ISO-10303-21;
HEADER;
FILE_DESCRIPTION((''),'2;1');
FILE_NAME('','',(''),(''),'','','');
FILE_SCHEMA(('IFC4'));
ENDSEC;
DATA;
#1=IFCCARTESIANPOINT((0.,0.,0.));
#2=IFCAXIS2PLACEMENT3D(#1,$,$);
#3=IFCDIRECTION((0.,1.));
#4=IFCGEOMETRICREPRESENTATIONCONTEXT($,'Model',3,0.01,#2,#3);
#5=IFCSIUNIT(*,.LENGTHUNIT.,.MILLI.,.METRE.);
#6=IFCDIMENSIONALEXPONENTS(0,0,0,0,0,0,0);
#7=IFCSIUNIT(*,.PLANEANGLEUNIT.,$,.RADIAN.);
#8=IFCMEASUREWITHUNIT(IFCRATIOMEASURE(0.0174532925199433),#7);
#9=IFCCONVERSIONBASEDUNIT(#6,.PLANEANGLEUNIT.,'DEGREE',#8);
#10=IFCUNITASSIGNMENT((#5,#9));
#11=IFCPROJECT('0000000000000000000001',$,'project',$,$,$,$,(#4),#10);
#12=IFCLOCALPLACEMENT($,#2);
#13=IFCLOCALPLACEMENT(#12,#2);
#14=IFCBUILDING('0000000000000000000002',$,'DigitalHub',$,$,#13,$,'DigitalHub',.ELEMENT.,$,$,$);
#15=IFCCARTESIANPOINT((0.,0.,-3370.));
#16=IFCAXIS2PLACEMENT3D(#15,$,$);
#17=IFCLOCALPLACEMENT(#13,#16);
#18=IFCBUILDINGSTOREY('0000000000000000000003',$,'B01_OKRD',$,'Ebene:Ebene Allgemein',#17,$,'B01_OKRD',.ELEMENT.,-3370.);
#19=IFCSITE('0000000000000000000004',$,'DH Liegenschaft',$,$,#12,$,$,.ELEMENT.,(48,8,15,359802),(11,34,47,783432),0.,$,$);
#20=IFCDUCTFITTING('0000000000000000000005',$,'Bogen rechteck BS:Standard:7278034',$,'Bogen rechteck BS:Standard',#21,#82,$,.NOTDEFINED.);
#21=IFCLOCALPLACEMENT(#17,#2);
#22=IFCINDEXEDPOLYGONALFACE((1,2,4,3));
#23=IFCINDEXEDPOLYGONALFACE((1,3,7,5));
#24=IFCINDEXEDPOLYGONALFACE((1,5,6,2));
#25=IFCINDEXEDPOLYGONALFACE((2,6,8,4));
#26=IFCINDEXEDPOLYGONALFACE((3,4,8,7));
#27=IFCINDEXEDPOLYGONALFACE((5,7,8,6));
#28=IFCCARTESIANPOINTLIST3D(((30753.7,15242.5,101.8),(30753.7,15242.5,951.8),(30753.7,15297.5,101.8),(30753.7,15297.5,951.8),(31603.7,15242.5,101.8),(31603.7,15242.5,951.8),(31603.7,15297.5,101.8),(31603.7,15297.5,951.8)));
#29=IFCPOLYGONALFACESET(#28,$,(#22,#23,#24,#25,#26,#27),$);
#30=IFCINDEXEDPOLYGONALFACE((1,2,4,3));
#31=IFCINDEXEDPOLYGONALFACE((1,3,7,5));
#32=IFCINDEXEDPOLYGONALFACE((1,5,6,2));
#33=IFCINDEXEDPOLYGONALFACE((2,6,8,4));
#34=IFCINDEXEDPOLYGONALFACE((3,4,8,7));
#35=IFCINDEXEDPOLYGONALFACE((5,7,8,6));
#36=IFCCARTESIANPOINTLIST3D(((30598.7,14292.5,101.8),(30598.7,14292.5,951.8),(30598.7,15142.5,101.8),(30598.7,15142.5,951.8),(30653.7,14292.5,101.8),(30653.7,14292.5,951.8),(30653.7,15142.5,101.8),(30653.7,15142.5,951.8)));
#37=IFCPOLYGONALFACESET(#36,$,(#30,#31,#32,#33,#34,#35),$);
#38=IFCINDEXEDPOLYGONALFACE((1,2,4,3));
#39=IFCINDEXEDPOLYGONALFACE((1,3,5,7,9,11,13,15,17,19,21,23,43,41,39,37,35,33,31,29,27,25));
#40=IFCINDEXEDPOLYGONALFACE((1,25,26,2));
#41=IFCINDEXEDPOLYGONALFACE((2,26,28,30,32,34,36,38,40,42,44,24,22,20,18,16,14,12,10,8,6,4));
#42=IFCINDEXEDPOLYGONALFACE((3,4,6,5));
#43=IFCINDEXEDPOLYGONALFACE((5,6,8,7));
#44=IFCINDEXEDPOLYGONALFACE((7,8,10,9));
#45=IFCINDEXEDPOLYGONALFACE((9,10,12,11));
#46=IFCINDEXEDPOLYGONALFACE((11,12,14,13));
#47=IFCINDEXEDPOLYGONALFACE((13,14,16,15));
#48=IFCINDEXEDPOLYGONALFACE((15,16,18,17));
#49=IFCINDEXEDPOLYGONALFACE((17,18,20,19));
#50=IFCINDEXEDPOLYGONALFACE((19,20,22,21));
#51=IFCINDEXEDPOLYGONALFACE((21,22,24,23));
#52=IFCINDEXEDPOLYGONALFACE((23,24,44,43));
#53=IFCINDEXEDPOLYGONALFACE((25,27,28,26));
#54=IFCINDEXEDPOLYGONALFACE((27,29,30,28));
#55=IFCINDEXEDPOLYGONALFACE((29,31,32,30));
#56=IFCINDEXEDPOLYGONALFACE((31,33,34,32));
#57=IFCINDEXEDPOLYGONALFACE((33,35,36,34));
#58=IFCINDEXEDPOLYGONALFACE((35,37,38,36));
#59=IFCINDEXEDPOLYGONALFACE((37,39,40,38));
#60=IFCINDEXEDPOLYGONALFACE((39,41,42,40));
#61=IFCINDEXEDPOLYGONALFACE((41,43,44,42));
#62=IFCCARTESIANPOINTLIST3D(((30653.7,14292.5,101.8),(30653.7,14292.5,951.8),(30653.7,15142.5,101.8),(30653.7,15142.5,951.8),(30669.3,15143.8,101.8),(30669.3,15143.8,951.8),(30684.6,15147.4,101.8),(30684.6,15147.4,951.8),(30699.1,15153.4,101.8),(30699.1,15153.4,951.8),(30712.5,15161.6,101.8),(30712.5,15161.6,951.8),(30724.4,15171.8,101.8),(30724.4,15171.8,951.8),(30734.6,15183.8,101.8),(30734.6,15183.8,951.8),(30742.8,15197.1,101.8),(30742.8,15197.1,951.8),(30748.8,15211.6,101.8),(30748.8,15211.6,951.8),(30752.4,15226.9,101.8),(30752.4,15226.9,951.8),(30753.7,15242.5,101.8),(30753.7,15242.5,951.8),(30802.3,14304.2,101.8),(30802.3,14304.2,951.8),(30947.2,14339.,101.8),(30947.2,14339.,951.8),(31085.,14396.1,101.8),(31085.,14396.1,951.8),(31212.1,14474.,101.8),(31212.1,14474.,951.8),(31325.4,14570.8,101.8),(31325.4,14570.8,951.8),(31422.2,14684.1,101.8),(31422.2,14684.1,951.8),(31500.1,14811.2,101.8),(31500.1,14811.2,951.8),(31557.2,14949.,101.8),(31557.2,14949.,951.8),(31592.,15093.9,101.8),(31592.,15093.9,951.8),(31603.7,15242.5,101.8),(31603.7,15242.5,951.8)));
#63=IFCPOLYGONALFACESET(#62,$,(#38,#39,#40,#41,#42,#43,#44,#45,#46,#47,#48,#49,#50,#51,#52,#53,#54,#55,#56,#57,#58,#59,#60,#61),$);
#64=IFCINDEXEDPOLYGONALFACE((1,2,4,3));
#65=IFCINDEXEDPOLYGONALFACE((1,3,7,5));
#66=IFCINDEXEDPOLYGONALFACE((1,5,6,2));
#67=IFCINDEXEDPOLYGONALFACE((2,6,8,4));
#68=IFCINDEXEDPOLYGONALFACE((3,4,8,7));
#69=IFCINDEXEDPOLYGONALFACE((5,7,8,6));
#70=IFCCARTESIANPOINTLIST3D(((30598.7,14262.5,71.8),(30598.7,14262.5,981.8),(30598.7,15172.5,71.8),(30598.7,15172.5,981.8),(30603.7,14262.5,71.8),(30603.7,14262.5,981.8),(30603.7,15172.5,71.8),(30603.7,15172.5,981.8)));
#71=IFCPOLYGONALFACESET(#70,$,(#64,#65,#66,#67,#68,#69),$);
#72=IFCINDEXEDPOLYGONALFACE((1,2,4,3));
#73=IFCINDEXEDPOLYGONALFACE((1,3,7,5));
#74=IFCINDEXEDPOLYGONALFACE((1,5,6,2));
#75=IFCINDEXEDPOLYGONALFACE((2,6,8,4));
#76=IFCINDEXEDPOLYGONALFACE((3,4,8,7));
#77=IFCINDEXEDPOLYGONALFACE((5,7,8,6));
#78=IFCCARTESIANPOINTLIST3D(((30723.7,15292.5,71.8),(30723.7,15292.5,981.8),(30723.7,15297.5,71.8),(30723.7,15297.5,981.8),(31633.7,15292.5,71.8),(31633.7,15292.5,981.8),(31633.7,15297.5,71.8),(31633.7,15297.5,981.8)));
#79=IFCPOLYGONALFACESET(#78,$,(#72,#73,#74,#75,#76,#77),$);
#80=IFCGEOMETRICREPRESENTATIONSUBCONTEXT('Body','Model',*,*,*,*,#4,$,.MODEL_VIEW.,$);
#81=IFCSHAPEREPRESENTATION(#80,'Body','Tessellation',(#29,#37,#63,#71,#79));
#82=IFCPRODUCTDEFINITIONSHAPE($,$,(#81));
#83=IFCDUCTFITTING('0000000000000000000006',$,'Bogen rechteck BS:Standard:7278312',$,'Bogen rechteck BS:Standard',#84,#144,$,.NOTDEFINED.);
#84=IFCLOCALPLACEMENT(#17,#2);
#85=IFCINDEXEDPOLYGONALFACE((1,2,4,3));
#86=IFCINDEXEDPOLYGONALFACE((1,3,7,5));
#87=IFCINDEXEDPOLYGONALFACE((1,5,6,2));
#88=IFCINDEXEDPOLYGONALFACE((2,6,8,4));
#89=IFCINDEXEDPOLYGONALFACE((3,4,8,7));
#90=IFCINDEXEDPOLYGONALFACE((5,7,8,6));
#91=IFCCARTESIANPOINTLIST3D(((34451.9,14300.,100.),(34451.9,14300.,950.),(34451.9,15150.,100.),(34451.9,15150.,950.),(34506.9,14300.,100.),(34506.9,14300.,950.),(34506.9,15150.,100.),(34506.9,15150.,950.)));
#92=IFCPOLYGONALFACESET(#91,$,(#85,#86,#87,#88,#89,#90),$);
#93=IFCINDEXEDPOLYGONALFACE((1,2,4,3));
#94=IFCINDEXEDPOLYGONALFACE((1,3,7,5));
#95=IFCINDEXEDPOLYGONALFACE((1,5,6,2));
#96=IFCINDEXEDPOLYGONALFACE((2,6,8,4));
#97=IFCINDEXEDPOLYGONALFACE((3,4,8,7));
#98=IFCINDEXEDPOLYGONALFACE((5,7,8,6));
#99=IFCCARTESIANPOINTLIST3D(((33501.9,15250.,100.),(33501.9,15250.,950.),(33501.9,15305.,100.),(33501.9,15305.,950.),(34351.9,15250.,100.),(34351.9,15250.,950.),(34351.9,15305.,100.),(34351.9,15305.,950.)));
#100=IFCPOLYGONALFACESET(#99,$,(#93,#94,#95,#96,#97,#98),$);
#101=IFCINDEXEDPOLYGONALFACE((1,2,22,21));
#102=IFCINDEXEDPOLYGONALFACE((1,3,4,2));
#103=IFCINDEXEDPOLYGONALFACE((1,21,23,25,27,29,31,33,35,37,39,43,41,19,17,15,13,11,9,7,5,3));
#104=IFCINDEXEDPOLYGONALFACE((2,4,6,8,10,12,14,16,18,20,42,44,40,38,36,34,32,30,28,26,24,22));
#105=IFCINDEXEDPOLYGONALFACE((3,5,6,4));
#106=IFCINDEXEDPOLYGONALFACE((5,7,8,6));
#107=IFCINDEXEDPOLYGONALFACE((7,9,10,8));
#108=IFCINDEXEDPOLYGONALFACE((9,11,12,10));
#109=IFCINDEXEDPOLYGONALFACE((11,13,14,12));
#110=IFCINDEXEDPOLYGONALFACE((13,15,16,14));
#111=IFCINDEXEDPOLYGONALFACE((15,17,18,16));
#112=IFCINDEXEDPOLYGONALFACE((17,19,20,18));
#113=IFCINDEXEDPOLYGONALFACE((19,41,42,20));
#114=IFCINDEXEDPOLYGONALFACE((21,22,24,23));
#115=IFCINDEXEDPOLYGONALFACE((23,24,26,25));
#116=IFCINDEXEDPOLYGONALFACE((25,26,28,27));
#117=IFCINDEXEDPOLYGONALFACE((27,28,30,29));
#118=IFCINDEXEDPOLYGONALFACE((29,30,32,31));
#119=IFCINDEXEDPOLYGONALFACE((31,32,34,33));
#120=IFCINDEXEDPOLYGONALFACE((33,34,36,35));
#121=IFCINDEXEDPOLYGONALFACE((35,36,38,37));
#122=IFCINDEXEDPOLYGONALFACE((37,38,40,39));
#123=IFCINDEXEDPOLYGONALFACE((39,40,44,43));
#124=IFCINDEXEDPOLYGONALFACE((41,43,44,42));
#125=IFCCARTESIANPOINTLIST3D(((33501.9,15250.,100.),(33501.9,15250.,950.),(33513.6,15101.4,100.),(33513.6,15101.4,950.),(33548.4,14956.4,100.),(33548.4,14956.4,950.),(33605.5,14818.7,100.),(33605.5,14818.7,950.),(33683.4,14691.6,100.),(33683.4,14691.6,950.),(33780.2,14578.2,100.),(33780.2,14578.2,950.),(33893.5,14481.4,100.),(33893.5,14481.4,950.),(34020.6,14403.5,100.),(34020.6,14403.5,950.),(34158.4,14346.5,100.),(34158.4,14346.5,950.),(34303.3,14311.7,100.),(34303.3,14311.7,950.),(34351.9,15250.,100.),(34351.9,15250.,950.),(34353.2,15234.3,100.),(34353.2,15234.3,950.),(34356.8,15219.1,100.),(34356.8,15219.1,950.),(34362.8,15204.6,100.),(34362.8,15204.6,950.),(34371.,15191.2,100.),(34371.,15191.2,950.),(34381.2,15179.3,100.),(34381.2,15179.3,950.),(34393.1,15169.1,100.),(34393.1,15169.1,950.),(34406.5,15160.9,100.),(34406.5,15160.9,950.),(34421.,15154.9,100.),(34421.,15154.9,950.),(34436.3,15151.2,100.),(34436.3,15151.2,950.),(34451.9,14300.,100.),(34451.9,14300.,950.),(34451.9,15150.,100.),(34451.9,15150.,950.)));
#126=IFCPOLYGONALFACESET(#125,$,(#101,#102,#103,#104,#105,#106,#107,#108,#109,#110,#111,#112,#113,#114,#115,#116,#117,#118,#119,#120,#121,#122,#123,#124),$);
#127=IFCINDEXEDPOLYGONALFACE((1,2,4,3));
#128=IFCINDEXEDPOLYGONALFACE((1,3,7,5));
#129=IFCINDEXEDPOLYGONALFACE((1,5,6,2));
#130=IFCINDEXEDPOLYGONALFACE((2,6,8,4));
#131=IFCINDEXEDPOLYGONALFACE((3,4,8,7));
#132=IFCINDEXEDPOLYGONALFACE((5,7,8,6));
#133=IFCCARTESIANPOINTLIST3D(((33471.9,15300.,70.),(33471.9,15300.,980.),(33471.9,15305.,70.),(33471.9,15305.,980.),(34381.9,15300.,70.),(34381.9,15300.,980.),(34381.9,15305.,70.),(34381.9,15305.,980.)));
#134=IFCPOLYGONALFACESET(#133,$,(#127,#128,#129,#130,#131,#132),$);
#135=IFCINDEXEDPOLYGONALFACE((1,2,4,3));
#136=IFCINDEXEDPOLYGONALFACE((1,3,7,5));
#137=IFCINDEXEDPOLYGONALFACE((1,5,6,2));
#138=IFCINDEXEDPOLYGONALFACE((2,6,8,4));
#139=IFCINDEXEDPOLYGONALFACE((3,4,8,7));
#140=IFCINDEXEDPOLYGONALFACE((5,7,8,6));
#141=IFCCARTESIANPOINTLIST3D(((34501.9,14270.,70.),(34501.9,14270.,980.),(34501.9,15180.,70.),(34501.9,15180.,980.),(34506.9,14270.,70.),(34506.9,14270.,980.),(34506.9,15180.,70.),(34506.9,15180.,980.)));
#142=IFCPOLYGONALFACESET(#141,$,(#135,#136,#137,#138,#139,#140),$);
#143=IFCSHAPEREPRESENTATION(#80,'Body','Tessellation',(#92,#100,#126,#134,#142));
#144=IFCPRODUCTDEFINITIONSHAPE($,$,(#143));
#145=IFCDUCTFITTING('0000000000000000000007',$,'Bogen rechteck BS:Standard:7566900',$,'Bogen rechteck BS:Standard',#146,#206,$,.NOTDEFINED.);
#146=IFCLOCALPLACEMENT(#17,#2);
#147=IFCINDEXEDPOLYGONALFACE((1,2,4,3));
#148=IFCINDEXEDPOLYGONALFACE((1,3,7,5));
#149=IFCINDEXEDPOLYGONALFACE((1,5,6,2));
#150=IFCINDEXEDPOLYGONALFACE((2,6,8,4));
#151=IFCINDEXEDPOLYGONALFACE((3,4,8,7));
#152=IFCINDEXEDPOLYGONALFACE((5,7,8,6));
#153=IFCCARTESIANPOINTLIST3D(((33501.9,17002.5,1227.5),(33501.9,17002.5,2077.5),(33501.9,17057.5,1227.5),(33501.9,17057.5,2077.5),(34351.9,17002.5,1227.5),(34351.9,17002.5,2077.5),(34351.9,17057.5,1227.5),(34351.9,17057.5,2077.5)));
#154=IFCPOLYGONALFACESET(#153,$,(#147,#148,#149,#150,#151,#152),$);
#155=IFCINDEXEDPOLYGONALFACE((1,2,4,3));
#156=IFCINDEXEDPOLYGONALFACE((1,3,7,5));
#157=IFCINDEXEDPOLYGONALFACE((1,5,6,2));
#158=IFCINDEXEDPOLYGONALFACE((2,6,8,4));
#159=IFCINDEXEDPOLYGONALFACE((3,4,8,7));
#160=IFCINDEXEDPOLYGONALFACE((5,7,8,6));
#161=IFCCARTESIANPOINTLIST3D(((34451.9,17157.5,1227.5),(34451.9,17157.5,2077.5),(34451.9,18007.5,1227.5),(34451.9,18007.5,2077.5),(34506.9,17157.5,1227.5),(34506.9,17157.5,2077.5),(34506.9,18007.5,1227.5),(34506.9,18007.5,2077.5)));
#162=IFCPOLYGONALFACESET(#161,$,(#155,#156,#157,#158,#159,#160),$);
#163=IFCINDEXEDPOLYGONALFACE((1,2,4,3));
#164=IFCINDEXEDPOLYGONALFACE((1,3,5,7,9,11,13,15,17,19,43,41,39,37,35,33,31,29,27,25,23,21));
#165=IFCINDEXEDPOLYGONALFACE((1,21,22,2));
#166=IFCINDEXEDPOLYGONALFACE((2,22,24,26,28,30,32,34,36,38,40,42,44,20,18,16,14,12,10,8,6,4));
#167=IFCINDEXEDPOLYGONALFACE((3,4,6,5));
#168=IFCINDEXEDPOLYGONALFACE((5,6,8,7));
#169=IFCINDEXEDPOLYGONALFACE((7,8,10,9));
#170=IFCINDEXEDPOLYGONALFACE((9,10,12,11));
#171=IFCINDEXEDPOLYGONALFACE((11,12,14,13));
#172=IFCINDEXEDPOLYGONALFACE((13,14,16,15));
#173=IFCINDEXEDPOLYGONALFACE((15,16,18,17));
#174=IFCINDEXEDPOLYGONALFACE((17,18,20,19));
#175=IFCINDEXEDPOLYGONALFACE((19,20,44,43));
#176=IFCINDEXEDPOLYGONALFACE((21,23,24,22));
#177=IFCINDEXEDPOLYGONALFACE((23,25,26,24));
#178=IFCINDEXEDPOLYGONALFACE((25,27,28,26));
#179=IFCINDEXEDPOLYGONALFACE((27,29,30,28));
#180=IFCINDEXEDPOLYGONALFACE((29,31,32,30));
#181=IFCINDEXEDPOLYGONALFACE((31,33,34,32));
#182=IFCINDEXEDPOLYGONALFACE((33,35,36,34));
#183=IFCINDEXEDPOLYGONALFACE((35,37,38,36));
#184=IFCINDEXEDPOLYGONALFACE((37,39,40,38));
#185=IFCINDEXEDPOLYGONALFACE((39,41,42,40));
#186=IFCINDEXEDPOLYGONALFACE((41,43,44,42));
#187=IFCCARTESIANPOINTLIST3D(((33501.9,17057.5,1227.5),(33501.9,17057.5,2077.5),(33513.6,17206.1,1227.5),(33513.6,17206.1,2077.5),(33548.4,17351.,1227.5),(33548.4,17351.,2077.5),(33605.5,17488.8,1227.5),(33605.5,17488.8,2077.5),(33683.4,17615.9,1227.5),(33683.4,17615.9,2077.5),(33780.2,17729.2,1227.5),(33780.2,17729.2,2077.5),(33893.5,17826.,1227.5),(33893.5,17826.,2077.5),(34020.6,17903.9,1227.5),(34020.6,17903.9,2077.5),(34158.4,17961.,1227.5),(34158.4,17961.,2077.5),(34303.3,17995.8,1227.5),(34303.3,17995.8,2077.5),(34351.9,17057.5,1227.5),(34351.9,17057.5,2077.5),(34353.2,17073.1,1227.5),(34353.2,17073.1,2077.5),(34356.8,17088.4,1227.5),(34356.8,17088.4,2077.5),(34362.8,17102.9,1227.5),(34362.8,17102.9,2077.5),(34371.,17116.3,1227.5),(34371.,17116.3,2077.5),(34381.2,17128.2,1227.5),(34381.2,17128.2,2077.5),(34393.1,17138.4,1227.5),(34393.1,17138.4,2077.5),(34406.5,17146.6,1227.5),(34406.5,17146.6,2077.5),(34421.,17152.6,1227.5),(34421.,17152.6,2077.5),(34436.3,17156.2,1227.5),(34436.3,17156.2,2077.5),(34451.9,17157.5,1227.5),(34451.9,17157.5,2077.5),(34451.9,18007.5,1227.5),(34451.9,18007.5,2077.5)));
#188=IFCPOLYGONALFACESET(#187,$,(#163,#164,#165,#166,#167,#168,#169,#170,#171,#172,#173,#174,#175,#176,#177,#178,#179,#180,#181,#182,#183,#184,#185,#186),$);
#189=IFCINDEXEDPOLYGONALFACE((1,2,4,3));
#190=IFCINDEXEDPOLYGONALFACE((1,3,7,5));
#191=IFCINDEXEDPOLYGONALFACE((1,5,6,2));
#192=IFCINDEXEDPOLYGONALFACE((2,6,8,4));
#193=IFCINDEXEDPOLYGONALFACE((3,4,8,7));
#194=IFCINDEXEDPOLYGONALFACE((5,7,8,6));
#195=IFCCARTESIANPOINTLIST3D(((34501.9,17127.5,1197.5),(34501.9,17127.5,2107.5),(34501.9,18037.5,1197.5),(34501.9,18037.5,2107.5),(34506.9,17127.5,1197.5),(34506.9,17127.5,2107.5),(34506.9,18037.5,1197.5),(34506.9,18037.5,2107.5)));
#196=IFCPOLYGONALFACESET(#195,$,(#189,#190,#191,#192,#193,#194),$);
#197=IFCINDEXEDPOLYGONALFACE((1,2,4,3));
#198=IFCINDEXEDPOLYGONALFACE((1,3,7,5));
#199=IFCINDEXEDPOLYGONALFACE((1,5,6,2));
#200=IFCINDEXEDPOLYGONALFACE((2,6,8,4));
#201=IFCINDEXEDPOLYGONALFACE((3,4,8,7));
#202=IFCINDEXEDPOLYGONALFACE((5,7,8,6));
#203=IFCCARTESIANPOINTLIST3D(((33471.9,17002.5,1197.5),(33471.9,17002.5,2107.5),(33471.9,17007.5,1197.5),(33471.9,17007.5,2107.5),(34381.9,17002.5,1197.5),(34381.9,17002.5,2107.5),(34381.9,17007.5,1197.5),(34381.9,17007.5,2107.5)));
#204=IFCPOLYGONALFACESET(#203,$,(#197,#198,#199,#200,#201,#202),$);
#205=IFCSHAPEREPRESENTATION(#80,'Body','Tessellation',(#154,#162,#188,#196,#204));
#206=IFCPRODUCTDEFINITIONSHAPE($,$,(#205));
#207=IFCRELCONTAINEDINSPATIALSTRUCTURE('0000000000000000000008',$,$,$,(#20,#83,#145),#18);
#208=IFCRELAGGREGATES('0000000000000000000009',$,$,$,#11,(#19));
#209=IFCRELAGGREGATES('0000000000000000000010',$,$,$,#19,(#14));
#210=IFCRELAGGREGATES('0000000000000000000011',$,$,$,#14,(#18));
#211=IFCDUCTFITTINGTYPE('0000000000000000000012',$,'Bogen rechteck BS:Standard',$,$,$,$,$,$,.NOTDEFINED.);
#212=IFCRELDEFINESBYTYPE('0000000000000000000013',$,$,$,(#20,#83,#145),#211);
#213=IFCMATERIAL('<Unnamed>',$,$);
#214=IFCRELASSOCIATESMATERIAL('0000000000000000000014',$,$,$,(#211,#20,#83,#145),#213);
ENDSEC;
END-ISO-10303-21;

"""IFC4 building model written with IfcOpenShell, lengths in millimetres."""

from ifc_helpers import new_model, entity, si_unit, converted_unit, direction, frame, origin, place, context, subcontext, project, spatial, indexed_curve, outline, extrude, source, transform, mapped, material, type_object, type_shapes, element, save


model = new_model("IFC4")

# Units and contexts
model_context = context("Model", 3, precision=0.01, world=origin(), true_north=direction((0.0, 1.0)))
body_context = subcontext(model_context, "Body", "Model", "MODEL_VIEW")
ifc_project = project(units=[si_unit("LENGTHUNIT", "METRE", prefix="MILLI"), converted_unit("PLANEANGLEUNIT", "DEGREE", entity("IfcRatioMeasure", 0.0174532925199433), si_unit("PLANEANGLEUNIT", "RADIAN"), dimensions=[0, 0, 0, 0, 0, 0, 0])], contexts=[model_context])

# Site, building, storey
site_placement = place(None, origin())
site = spatial("IfcSite", under=ifc_project, at=site_placement, Name="DH Liegenschaft", CompositionType="ELEMENT", RefLatitude=(48, 8, 15, 359802), RefLongitude=(11, 34, 47, 783432), RefElevation=0.0)
building_placement = place(site_placement, origin())
building = spatial("IfcBuilding", under=site, at=building_placement, Name="DigitalHub", LongName="DigitalHub", CompositionType="ELEMENT")
storey_placement = place(building_placement, frame((0.0, 0.0, -3370.0)))
storey = spatial("IfcBuildingStorey", under=building, at=storey_placement, Name="B01_OKRD", ObjectType="Ebene:Ebene Allgemein", LongName="B01_OKRD", CompositionType="ELEMENT", Elevation=-3370.0)

# Duct fittings
ifc_material_1 = material(Name="<Unnamed>")
duct_fitting_type_1 = type_object("IfcDuctFittingType", Name="Bogen rechteck BS:Standard", PredefinedType="NOTDEFINED", material=ifc_material_1)
shared_shape_1 = source(origin(), body_context, "Body", "SweptSolid", [
    extrude(outline(indexed_curve([(-27.5, -425.0), (27.5, -425.0), (27.5, 425.0), (-27.5, 425.0), (-27.5, -425.0)], self_intersect=False)), frame((0.0, 552.5, -425.0), z_axis=(0.0, 0.0, 1.0), x_axis=(0.0, 1.0, 0.0)), (0.0, 0.0, 1.0), 850.0),
    extrude(outline(indexed_curve([(-425.0, -27.5), (425.0, -27.5), (425.0, 27.5), (-425.0, 27.5), (-425.0, -27.5)], self_intersect=False)), frame((-552.5, 0.0, -425.0), z_axis=(0.0, 0.0, 1.0), x_axis=(0.0, -1.0, 0.0)), (0.0, 0.0, 1.0), 850.0),
    extrude(outline(indexed_curve([(-687.5, -262.5), (162.5, -262.5), (163.7, -246.9), (167.4, -231.6), (173.4, -217.1), (181.6, -203.7), (191.8, -191.8), (203.7, -181.6), (217.1, -173.4), (231.6, -167.4), (246.9, -163.7), (262.5, -162.5), (262.5, 687.5), (113.9, 675.8), (-31.1, 641.0), (-168.8, 584.0), (-295.9, 506.1), (-409.3, 409.3), (-506.1, 295.9), (-584.0, 168.8), (-641.0, 31.1), (-675.8, -113.9), (-687.5, -262.5)], self_intersect=False)), frame((-262.5, 262.5, -425.0), z_axis=(0.0, 0.0, 1.0), x_axis=(-1.0, 0.0, 0.0)), (0.0, 0.0, 1.0), 850.0),
    extrude(outline(indexed_curve([(-2.5, -455.0), (2.5, -455.0), (2.5, 455.0), (-2.5, 455.0), (-2.5, -455.0)], self_intersect=False)), frame((-577.5, 0.0, -455.0)), (0.0, 0.0, 1.0), 910.0),
    extrude(outline(indexed_curve([(-2.5, -455.0), (2.5, -455.0), (2.5, 455.0), (-2.5, 455.0), (-2.5, -455.0)], self_intersect=False)), frame((0.0, 577.5, -455.0), z_axis=(0.0, 0.0, 1.0), x_axis=(0.0, 1.0, 0.0)), (0.0, 0.0, 1.0), 910.0),
])
type_shapes(duct_fitting_type_1, [shared_shape_1])
duct_fitting_1_placement = place(storey_placement, frame((31178.7, 14717.5, 526.8)))
element("IfcDuctFitting", 1, at=duct_fitting_1_placement, inside=storey, type_object=duct_fitting_type_1, material=ifc_material_1, Name="Bogen rechteck BS:Standard:7278034", ObjectType="Bogen rechteck BS:Standard", PredefinedType="NOTDEFINED", context=body_context, shape_type="MappedRepresentation", body=[
    mapped(shared_shape_1, transform((0.0, 0.0, 0.0), scale=1.0)),
])
for number, where, z_axis, x_axis, name in (
    (2, (33926.9, 14725.0, 525.0), (0.0, 0.0, 1.0), (0.0, -1.0, 0.0), "Bogen rechteck BS:Standard:7278312"),
    (3, (33926.9, 17582.5, 1652.5), (0.0, 0.0, 1.0), (-1.0, 0.0, 0.0), "Bogen rechteck BS:Standard:7566900"),
):
    element("IfcDuctFitting", number, at=place(storey_placement, frame(where, z_axis=z_axis, x_axis=x_axis)), inside=storey, type_object=duct_fitting_type_1, material=ifc_material_1, Name=name, ObjectType="Bogen rechteck BS:Standard", PredefinedType="NOTDEFINED", context=body_context, shape_type="MappedRepresentation", body=[
        mapped(shared_shape_1, transform((0.0, 0.0, 0.0), scale=1.0)),
    ])

save(model, "model.ifc")
